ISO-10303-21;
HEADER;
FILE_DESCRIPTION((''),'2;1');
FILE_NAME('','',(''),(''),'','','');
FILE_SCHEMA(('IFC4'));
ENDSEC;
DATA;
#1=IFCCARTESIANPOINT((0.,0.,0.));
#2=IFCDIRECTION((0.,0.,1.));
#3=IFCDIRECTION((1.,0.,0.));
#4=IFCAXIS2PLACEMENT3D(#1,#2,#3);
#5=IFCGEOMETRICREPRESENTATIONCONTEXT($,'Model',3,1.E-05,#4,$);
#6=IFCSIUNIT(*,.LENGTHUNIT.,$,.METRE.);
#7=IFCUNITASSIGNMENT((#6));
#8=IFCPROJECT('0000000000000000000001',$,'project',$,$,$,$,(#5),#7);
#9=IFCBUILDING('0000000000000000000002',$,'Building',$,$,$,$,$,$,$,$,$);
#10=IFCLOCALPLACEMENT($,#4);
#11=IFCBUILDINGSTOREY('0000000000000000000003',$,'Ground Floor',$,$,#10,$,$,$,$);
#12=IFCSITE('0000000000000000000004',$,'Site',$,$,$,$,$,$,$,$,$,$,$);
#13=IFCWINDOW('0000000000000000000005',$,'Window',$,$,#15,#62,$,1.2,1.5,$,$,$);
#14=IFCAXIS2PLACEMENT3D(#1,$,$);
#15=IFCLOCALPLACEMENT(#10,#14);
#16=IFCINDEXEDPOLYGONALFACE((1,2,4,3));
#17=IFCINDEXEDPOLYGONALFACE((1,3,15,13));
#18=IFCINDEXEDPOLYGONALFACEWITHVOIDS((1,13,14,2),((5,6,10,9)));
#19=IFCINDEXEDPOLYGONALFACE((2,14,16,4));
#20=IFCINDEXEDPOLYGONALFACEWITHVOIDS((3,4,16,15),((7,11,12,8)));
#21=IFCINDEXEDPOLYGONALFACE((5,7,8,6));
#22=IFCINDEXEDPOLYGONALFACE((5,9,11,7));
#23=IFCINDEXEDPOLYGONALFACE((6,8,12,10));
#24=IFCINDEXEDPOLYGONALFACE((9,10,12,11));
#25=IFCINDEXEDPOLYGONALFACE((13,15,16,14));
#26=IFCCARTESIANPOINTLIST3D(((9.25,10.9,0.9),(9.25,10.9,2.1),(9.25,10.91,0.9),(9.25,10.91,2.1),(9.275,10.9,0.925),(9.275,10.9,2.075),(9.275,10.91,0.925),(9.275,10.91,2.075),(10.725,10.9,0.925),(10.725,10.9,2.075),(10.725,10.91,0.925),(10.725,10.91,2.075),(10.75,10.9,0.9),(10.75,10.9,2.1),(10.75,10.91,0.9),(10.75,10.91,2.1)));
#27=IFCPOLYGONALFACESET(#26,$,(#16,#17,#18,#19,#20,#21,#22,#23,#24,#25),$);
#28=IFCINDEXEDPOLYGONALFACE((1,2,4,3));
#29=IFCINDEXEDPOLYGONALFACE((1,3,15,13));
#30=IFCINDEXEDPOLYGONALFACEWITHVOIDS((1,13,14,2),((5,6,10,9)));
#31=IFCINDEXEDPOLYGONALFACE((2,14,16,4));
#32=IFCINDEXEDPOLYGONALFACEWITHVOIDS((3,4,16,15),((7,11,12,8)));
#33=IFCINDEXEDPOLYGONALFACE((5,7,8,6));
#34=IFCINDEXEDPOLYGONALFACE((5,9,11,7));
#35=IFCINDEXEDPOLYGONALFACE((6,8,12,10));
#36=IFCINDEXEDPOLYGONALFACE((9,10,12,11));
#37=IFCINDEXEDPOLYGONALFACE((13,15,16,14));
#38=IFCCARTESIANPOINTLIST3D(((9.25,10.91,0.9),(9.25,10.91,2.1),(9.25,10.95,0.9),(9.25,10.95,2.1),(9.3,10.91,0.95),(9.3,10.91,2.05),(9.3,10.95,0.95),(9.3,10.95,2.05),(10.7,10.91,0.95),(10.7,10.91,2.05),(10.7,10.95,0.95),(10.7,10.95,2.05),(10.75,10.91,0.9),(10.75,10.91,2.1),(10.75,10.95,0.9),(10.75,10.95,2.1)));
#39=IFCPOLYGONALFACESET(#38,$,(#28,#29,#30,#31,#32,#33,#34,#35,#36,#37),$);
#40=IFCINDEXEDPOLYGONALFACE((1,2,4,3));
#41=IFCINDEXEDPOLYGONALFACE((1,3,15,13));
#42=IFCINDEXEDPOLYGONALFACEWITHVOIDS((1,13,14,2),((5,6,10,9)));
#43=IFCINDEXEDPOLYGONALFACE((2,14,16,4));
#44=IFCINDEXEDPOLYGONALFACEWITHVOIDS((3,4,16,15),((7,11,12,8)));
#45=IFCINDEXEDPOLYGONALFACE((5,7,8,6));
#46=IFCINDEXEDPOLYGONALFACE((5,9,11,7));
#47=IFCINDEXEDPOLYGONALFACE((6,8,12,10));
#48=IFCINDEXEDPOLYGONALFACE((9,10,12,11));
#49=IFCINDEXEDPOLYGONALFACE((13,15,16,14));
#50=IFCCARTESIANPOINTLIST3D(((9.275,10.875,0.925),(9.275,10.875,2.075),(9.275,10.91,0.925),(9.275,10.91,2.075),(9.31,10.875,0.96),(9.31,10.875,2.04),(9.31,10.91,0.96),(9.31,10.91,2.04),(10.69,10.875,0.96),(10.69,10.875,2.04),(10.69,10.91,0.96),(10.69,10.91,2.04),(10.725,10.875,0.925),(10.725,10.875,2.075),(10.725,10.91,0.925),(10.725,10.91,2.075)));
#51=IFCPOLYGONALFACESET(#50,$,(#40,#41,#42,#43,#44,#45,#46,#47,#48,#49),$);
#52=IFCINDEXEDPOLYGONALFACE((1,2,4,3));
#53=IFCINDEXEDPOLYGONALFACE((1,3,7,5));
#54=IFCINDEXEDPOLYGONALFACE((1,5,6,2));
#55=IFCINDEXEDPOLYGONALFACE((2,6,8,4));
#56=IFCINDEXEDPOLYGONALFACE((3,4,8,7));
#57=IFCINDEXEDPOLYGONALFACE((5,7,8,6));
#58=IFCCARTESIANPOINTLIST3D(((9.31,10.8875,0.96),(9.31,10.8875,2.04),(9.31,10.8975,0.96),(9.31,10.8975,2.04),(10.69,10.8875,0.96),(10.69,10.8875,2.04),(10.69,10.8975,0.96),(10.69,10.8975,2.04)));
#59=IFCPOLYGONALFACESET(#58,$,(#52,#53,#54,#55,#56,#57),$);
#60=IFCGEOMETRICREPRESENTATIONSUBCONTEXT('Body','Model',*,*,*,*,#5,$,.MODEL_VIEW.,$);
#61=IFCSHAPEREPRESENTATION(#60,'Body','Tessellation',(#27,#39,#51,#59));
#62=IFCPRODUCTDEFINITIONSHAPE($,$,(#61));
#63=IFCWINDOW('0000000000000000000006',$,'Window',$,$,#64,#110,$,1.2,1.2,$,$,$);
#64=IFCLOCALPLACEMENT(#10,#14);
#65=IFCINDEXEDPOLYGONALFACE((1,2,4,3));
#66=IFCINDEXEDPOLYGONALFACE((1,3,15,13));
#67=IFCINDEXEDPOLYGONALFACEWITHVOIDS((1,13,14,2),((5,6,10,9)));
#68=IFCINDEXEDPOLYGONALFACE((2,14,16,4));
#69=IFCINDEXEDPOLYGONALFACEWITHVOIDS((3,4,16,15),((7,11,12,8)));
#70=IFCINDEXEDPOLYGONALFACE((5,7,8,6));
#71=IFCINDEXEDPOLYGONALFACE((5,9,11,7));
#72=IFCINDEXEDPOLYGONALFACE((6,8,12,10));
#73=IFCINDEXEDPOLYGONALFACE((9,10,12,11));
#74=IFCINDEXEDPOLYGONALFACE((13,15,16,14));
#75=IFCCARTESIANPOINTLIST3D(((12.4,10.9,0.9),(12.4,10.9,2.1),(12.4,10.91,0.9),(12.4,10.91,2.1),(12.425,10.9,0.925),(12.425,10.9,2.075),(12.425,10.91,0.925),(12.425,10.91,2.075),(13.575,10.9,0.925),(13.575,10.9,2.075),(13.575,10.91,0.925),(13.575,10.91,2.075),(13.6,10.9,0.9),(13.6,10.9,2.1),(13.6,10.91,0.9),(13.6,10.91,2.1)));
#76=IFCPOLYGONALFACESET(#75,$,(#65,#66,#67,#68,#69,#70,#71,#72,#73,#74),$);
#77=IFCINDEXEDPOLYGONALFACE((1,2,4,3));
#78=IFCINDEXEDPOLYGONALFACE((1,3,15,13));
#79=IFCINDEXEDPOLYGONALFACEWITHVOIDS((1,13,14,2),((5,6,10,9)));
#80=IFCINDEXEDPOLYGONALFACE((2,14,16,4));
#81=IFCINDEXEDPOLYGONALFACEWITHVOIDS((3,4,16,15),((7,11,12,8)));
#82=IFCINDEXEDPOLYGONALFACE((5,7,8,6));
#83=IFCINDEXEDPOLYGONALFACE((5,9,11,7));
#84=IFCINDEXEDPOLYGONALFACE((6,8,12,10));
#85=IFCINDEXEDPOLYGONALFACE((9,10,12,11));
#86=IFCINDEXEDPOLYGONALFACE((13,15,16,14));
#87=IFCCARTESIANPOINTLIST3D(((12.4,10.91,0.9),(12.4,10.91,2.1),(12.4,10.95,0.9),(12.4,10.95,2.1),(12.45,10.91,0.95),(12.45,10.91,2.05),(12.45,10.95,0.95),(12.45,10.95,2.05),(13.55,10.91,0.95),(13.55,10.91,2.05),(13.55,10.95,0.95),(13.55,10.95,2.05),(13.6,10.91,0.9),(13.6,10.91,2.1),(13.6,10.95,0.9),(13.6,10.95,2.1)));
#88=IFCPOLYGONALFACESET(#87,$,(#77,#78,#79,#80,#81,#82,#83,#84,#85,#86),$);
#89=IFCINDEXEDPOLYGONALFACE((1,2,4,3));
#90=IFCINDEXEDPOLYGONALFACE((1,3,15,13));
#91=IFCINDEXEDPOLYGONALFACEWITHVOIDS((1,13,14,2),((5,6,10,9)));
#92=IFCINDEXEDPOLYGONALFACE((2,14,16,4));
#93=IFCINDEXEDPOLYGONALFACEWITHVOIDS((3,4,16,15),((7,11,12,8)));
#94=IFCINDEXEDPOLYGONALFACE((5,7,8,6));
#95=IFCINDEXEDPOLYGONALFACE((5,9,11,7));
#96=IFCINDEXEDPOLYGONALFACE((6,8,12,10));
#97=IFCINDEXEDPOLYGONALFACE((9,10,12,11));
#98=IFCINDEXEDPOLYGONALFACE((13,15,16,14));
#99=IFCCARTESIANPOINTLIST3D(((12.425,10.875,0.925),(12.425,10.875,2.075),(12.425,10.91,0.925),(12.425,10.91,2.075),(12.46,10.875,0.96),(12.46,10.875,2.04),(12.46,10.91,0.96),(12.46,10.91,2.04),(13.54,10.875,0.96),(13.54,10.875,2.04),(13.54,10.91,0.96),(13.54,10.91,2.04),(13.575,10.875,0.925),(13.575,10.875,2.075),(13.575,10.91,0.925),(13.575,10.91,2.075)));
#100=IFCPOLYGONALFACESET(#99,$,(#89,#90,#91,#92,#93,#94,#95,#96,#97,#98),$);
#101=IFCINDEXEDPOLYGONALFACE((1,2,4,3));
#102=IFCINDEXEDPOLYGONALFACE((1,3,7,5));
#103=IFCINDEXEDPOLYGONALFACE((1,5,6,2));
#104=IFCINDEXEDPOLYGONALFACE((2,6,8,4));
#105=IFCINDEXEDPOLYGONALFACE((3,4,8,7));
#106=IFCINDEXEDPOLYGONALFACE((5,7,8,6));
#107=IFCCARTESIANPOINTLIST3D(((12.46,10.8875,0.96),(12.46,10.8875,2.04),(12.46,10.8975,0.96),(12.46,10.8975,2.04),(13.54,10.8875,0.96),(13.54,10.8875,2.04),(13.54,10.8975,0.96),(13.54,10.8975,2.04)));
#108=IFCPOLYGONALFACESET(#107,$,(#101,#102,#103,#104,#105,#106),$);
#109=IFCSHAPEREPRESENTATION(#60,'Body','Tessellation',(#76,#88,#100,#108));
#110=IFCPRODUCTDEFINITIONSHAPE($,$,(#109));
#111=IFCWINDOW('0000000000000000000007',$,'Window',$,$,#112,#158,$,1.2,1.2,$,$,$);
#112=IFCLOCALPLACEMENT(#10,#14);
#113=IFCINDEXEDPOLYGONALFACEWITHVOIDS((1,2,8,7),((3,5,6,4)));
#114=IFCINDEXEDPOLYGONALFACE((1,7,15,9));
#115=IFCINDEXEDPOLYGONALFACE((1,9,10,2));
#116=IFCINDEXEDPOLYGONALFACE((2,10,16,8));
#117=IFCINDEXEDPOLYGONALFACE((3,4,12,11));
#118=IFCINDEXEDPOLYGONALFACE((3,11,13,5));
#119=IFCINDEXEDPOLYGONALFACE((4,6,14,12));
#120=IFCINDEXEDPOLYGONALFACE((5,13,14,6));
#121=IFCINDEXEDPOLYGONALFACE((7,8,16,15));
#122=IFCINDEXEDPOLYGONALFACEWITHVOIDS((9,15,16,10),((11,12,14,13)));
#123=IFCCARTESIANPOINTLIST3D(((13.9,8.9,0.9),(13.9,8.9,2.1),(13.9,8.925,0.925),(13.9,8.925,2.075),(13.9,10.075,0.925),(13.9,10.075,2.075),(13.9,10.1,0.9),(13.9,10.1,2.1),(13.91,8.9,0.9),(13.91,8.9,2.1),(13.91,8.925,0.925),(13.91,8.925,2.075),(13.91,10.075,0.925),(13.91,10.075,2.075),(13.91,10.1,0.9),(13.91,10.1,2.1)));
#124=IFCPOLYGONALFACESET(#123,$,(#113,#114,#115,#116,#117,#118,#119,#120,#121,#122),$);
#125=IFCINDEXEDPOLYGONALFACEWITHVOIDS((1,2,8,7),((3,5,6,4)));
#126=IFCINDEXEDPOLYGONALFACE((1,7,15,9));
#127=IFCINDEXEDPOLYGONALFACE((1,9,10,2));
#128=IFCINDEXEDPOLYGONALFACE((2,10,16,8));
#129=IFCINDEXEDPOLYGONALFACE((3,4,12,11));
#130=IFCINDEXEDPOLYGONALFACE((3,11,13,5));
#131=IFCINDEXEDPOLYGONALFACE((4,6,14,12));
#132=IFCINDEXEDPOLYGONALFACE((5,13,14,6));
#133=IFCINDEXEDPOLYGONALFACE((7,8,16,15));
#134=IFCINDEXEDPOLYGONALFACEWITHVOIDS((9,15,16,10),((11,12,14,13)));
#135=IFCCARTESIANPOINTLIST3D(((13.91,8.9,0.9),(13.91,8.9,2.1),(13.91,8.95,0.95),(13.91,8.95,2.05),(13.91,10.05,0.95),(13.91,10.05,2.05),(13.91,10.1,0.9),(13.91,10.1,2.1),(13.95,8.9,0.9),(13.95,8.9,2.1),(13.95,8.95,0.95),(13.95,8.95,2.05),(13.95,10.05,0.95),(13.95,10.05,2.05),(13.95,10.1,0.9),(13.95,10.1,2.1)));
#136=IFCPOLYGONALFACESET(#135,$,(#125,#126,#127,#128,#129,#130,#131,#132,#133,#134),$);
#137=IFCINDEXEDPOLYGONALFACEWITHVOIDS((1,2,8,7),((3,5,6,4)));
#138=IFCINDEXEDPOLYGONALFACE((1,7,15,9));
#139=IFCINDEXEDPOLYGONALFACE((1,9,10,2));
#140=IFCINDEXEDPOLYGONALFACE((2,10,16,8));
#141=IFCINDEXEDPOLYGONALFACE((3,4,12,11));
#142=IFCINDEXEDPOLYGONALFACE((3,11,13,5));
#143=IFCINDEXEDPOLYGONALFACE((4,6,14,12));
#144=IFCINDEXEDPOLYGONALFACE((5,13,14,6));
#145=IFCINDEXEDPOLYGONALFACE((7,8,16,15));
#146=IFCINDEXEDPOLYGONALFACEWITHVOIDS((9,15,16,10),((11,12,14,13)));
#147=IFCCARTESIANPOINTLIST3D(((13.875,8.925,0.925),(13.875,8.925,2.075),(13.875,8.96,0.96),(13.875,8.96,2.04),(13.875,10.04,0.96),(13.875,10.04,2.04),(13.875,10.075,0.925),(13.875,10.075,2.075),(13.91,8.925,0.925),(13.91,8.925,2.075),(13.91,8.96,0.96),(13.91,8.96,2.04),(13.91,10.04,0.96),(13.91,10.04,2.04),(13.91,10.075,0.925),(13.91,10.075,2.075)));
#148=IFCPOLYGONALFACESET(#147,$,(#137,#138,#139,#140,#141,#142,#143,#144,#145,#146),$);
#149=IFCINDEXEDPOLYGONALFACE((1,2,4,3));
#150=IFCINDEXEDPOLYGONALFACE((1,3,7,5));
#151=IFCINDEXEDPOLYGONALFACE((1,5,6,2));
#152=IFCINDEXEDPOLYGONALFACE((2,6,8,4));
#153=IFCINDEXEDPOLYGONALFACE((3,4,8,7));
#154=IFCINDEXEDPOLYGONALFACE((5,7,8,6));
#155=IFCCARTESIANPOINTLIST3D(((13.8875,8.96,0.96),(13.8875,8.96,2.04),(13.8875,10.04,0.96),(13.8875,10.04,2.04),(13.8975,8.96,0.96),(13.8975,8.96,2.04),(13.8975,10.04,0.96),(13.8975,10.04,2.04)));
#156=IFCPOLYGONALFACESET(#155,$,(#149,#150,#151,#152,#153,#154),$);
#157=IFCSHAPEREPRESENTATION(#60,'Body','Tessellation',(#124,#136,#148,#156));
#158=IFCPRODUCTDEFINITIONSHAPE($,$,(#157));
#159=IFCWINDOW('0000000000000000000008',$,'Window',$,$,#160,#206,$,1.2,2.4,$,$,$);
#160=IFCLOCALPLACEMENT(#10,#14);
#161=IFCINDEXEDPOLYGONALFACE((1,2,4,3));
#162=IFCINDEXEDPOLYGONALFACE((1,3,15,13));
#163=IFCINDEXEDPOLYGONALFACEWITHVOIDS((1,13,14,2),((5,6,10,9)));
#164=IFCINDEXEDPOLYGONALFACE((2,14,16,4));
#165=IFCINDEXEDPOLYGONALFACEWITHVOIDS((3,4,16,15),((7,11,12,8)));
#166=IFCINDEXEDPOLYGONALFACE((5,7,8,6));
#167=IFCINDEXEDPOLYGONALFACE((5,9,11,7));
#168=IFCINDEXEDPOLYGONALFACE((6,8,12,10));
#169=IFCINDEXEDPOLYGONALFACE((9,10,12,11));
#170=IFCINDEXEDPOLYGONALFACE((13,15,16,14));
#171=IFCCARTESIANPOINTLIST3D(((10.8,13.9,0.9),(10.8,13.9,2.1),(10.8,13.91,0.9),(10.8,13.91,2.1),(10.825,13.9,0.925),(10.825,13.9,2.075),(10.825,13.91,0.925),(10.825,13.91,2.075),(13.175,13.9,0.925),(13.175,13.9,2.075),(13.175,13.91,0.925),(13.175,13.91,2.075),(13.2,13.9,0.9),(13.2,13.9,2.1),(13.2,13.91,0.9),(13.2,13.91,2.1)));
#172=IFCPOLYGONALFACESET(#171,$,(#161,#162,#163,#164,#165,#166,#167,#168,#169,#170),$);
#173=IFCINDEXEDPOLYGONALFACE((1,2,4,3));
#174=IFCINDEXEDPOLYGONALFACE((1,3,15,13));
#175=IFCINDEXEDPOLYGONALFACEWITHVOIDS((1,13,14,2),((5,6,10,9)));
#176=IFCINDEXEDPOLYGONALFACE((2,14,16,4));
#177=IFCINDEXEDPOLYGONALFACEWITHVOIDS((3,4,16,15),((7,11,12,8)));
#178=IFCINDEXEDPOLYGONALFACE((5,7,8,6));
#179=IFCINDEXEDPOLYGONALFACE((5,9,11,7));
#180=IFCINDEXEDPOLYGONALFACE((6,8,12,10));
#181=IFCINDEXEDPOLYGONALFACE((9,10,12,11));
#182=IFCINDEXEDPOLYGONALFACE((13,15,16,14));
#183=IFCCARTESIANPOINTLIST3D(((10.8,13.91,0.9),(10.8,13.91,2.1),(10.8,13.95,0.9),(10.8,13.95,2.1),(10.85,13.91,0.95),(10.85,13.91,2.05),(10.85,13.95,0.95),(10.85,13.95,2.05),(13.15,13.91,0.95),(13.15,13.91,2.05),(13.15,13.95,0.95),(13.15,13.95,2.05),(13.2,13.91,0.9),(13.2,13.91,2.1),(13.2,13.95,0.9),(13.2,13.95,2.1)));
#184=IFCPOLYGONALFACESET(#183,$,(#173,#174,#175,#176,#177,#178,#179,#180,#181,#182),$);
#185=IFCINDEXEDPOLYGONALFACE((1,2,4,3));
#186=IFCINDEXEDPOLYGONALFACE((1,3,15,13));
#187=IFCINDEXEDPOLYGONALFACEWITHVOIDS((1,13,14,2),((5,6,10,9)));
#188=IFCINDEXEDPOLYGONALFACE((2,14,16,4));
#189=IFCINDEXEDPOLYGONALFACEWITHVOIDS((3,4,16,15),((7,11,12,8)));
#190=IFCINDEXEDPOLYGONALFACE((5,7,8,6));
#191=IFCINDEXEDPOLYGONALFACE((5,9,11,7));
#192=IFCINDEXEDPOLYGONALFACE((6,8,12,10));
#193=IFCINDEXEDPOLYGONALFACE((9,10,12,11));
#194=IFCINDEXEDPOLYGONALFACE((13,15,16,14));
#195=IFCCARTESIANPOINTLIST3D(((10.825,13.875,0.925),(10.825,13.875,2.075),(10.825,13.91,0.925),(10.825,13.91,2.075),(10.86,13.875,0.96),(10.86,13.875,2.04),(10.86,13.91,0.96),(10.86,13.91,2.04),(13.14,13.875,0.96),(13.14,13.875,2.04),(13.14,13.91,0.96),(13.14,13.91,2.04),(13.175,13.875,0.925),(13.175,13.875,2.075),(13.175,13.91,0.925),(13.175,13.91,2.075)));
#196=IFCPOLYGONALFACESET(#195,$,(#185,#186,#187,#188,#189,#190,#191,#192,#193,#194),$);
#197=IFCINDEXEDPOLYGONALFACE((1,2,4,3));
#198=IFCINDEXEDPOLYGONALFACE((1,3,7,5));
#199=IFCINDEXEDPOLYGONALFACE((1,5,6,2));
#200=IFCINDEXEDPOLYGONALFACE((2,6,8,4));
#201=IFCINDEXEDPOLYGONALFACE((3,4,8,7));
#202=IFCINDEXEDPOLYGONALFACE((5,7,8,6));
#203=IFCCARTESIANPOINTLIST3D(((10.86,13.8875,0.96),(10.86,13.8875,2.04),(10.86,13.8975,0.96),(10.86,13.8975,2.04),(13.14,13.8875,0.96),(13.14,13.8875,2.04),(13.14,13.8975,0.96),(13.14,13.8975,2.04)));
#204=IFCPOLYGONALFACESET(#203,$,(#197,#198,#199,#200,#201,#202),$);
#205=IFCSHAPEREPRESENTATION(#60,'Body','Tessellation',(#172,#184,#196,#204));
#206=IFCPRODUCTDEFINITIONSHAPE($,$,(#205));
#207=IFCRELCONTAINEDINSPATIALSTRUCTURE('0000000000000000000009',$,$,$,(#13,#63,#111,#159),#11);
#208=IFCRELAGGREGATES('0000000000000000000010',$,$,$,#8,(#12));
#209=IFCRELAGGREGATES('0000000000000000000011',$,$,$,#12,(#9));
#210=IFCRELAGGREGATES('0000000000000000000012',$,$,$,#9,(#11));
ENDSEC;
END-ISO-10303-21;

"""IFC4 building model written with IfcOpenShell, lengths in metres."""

from ifc_helpers import new_model, si_unit, frame, origin_with_axes, place, context, subcontext, project, spatial, line, indexed_curve, outline, extrude, element, save


model = new_model("IFC4")

# Units and contexts
model_context = context("Model", 3, precision=1e-05, world=origin_with_axes())
body_context = subcontext(model_context, "Body", "Model", "MODEL_VIEW")
ifc_project = project(units=[si_unit("LENGTHUNIT", "METRE")], contexts=[model_context])

# Site, building, storey
site = spatial("IfcSite", under=ifc_project, Name="Site")
building = spatial("IfcBuilding", under=site, Name="Building")
storey_placement = place(None, origin_with_axes())
storey = spatial("IfcBuildingStorey", under=building, at=storey_placement, Name="Ground Floor")

# Windows
window_1_placement = place(storey_placement, frame((10.75, 11.0, 0.9), z_axis=(0.0, 0.0, 1.0), x_axis=(-1.0, 0.0, 0.0)))
element("IfcWindow", 1, at=window_1_placement, inside=storey, Name="Window", OverallHeight=1.2, OverallWidth=1.5, context=body_context, shape_type="SweptSolid", body=[
    extrude(outline(indexed_curve([(0.0, 0.0), (1.5, 0.0), (1.5, 1.2), (0.0, 1.2)], segments=[line(1, 2, 3, 4, 1)]), holes=[indexed_curve([(0.025, 0.025), (1.475, 0.025), (1.475, 1.175), (0.025, 1.175)], segments=[line(1, 2, 3, 4, 1)])]), frame((0.0, 0.09, 0.0), z_axis=(0.0, -1.0, 0.0), x_axis=(1.0, 0.0, 0.0)), (0.0, 0.0, -1.0), 0.01),
    extrude(outline(indexed_curve([(0.0, 0.0), (1.5, 0.0), (1.5, 1.2), (0.0, 1.2)], segments=[line(1, 2, 3, 4, 1)]), holes=[indexed_curve([(0.05, 0.05), (1.45, 0.05), (1.45, 1.15), (0.05, 1.15)], segments=[line(1, 2, 3, 4, 1)])]), frame((0.0, 0.05, 0.0), z_axis=(0.0, -1.0, 0.0), x_axis=(1.0, 0.0, 0.0)), (0.0, 0.0, -1.0), 0.04),
    extrude(outline(indexed_curve([(0.0, 0.0), (1.45, 0.0), (1.45, 1.15), (0.0, 1.15)], segments=[line(1, 2, 3, 4, 1)]), holes=[indexed_curve([(0.035, 0.035), (1.415, 0.035), (1.415, 1.115), (0.035, 1.115)], segments=[line(1, 2, 3, 4, 1)])]), frame((0.025, 0.09, 0.025), z_axis=(0.0, -1.0, 0.0), x_axis=(1.0, 0.0, 0.0)), (0.0, 0.0, -1.0), 0.035),
    extrude(outline(indexed_curve([(0.035, 0.035), (1.415, 0.035), (1.415, 1.115), (0.035, 1.115)], segments=[line(1, 2, 3, 4, 1)])), frame((0.025, 0.1025, 0.025), z_axis=(0.0, -1.0, 0.0), x_axis=(1.0, 0.0, 0.0)), (0.0, 0.0, -1.0), 0.01),
])
for number, where, z_axis, x_axis, name in (
    (2, (13.6, 11.0, 0.9), (0.0, 0.0, 1.0), (-1.0, 0.0, 0.0), "Window"),
    (3, (14.0, 8.9, 0.9), (0.0, 0.0, 1.0), (0.0, 1.0, 0.0), "Window"),
):
    element("IfcWindow", number, at=place(storey_placement, frame(where, z_axis=z_axis, x_axis=x_axis)), inside=storey, Name=name, OverallHeight=1.2, OverallWidth=1.2, context=body_context, shape_type="SweptSolid", body=[
        extrude(outline(indexed_curve([(0.0, 0.0), (1.2, 0.0), (1.2, 1.2), (0.0, 1.2)], segments=[line(1, 2, 3, 4, 1)]), holes=[indexed_curve([(0.025, 0.025), (1.175, 0.025), (1.175, 1.175), (0.025, 1.175)], segments=[line(1, 2, 3, 4, 1)])]), frame((0.0, 0.09, 0.0), z_axis=(0.0, -1.0, 0.0), x_axis=(1.0, 0.0, 0.0)), (0.0, 0.0, -1.0), 0.01),
        extrude(outline(indexed_curve([(0.0, 0.0), (1.2, 0.0), (1.2, 1.2), (0.0, 1.2)], segments=[line(1, 2, 3, 4, 1)]), holes=[indexed_curve([(0.05, 0.05), (1.15, 0.05), (1.15, 1.15), (0.05, 1.15)], segments=[line(1, 2, 3, 4, 1)])]), frame((0.0, 0.05, 0.0), z_axis=(0.0, -1.0, 0.0), x_axis=(1.0, 0.0, 0.0)), (0.0, 0.0, -1.0), 0.04),
        extrude(outline(indexed_curve([(0.0, 0.0), (1.15, 0.0), (1.15, 1.15), (0.0, 1.15)], segments=[line(1, 2, 3, 4, 1)]), holes=[indexed_curve([(0.035, 0.035), (1.115, 0.035), (1.115, 1.115), (0.035, 1.115)], segments=[line(1, 2, 3, 4, 1)])]), frame((0.025, 0.09, 0.025), z_axis=(0.0, -1.0, 0.0), x_axis=(1.0, 0.0, 0.0)), (0.0, 0.0, -1.0), 0.035),
        extrude(outline(indexed_curve([(0.035, 0.035), (1.115, 0.035), (1.115, 1.115), (0.035, 1.115)], segments=[line(1, 2, 3, 4, 1)])), frame((0.025, 0.1025, 0.025), z_axis=(0.0, -1.0, 0.0), x_axis=(1.0, 0.0, 0.0)), (0.0, 0.0, -1.0), 0.01),
    ])
window_2_placement = place(storey_placement, frame((13.2, 14.0, 0.9), z_axis=(0.0, 0.0, 1.0), x_axis=(-1.0, 0.0, 0.0)))
element("IfcWindow", 4, at=window_2_placement, inside=storey, Name="Window", OverallHeight=1.2, OverallWidth=2.4, context=body_context, shape_type="SweptSolid", body=[
    extrude(outline(indexed_curve([(0.0, 0.0), (2.4, 0.0), (2.4, 1.2), (0.0, 1.2)], segments=[line(1, 2, 3, 4, 1)]), holes=[indexed_curve([(0.025, 0.025), (2.375, 0.025), (2.375, 1.175), (0.025, 1.175)], segments=[line(1, 2, 3, 4, 1)])]), frame((0.0, 0.09, 0.0), z_axis=(0.0, -1.0, 0.0), x_axis=(1.0, 0.0, 0.0)), (0.0, 0.0, -1.0), 0.01),
    extrude(outline(indexed_curve([(0.0, 0.0), (2.4, 0.0), (2.4, 1.2), (0.0, 1.2)], segments=[line(1, 2, 3, 4, 1)]), holes=[indexed_curve([(0.05, 0.05), (2.35, 0.05), (2.35, 1.15), (0.05, 1.15)], segments=[line(1, 2, 3, 4, 1)])]), frame((0.0, 0.05, 0.0), z_axis=(0.0, -1.0, 0.0), x_axis=(1.0, 0.0, 0.0)), (0.0, 0.0, -1.0), 0.04),
    extrude(outline(indexed_curve([(0.0, 0.0), (2.35, 0.0), (2.35, 1.15), (0.0, 1.15)], segments=[line(1, 2, 3, 4, 1)]), holes=[indexed_curve([(0.035, 0.035), (2.315, 0.035), (2.315, 1.115), (0.035, 1.115)], segments=[line(1, 2, 3, 4, 1)])]), frame((0.025, 0.09, 0.025), z_axis=(0.0, -1.0, 0.0), x_axis=(1.0, 0.0, 0.0)), (0.0, 0.0, -1.0), 0.035),
    extrude(outline(indexed_curve([(0.035, 0.035), (2.315, 0.035), (2.315, 1.115), (0.035, 1.115)], segments=[line(1, 2, 3, 4, 1)])), frame((0.025, 0.1025, 0.025), z_axis=(0.0, -1.0, 0.0), x_axis=(1.0, 0.0, 0.0)), (0.0, 0.0, -1.0), 0.01),
])

save(model, "model.ifc")
